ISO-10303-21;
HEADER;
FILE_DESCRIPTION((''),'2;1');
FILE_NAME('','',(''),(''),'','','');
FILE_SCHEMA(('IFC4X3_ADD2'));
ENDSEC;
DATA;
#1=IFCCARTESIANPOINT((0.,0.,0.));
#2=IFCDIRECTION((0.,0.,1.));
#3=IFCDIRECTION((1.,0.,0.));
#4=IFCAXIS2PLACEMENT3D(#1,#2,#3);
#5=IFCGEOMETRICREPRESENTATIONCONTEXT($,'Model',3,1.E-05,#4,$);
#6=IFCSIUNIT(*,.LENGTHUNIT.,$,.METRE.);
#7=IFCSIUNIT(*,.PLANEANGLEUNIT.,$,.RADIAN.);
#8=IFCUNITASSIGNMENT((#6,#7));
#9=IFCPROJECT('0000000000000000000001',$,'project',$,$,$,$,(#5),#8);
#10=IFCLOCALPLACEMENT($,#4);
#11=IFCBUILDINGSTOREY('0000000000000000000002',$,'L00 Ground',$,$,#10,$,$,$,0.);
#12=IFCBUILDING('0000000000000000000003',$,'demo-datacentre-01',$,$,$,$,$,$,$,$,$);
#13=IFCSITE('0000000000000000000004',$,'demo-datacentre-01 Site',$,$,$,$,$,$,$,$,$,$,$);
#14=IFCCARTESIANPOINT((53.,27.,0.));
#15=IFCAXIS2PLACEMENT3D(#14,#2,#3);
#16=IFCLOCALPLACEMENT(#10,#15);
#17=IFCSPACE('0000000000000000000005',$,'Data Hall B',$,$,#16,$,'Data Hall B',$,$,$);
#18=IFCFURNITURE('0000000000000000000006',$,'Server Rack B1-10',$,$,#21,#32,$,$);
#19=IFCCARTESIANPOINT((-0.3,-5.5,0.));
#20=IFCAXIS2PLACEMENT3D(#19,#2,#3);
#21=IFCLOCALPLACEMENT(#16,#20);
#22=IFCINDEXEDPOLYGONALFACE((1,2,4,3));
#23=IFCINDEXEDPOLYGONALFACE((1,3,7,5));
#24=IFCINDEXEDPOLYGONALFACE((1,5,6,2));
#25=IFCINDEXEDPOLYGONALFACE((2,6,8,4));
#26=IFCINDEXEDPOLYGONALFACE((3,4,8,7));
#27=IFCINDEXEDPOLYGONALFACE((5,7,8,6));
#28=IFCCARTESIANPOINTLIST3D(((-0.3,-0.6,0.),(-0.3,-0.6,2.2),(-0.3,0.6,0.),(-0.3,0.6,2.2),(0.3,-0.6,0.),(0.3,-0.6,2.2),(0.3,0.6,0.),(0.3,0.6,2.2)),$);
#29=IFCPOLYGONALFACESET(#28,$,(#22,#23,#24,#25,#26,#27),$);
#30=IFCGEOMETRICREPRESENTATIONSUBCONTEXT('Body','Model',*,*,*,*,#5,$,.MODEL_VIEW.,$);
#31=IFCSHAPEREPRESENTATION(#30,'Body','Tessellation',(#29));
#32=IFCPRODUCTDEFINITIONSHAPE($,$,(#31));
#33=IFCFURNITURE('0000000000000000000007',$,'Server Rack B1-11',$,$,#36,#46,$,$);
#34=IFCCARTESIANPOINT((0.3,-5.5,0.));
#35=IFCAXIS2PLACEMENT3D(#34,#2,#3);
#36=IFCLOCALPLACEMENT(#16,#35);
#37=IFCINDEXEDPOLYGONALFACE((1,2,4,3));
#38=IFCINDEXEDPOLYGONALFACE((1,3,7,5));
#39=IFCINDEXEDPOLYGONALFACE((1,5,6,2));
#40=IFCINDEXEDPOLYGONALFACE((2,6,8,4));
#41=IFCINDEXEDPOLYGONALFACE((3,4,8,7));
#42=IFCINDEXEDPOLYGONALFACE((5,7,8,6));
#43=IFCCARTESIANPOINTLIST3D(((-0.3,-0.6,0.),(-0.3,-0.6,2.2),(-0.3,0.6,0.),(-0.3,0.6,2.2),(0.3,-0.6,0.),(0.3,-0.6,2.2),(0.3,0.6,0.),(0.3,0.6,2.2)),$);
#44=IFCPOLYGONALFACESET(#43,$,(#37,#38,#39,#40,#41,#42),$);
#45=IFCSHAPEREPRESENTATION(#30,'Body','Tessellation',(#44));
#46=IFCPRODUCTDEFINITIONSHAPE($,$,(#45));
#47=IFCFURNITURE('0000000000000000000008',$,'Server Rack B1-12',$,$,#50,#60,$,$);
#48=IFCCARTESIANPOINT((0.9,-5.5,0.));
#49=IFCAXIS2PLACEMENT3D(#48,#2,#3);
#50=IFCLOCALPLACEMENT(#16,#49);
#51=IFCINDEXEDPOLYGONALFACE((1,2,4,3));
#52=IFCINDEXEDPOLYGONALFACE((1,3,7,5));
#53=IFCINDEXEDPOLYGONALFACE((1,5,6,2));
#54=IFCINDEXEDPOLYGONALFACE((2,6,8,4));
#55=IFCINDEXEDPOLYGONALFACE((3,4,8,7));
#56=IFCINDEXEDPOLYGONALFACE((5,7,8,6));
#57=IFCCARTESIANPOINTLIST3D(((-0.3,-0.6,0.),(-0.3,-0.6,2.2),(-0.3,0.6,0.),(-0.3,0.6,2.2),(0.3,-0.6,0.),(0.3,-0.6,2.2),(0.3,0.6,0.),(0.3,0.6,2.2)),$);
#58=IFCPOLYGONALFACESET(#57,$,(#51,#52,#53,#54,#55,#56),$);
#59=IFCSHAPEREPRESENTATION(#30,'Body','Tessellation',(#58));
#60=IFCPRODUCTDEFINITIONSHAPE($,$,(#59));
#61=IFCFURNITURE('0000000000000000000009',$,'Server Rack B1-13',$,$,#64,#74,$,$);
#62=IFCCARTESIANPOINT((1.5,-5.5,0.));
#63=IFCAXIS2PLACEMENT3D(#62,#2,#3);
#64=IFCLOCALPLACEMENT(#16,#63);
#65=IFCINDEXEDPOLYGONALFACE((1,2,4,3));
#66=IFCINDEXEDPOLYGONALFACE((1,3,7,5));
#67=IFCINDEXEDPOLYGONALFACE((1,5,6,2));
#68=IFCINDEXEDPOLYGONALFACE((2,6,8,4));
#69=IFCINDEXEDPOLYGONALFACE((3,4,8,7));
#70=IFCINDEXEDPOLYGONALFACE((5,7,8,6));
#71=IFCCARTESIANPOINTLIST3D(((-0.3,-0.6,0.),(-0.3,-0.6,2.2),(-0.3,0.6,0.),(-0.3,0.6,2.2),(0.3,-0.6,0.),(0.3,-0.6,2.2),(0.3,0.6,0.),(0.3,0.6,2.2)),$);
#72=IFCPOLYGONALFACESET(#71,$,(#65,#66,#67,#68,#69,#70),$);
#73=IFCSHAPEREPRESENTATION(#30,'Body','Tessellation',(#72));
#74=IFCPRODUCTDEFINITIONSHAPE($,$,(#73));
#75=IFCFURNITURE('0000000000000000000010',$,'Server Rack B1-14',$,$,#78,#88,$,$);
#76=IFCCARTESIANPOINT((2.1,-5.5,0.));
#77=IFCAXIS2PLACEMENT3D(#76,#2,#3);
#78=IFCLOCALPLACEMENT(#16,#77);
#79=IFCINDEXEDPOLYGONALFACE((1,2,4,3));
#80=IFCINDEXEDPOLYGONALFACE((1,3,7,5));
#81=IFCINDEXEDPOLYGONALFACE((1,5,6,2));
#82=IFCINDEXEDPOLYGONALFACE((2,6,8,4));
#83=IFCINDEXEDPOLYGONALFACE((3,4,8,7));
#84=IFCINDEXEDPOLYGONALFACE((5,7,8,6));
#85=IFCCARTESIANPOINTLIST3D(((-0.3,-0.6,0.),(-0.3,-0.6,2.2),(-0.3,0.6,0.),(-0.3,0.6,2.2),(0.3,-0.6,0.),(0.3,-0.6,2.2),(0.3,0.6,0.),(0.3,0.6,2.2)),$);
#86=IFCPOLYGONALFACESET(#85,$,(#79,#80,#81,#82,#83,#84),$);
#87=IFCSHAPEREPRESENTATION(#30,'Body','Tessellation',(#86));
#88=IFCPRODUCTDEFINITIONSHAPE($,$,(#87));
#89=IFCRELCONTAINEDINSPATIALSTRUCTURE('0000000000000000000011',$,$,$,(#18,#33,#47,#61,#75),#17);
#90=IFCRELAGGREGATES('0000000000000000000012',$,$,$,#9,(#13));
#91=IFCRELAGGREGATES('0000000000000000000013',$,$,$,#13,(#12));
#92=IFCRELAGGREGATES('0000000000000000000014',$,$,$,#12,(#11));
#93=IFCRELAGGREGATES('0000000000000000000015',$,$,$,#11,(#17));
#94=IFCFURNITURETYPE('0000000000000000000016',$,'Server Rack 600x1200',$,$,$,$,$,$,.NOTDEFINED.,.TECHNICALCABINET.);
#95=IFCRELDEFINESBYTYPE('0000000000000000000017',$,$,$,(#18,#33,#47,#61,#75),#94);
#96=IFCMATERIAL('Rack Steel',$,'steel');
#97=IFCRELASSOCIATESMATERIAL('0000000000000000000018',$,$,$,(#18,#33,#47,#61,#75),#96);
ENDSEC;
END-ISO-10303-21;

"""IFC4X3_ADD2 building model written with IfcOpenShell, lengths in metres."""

from ifc_helpers import new_model, si_unit, frame, origin_with_axes, place, context, subcontext, project, spatial, rectangle, extrude, material, type_object, element, save


model = new_model("IFC4X3_ADD2")

# Units and contexts
model_context = context("Model", 3, precision=1e-05, world=origin_with_axes())
body_context = subcontext(model_context, "Body", "Model", "MODEL_VIEW")
ifc_project = project(units=[si_unit("LENGTHUNIT", "METRE"), si_unit("PLANEANGLEUNIT", "RADIAN")], contexts=[model_context])

# Site, building, storey
site = spatial("IfcSite", under=ifc_project, Name="demo-datacentre-01 Site")
building = spatial("IfcBuilding", under=site, Name="demo-datacentre-01")
storey_placement = place(None, origin_with_axes())
storey = spatial("IfcBuildingStorey", under=building, at=storey_placement, Name="L00 Ground", Elevation=0.0)

# Shared definitions
space_placement = place(storey_placement, frame((53.0, 27.0, 0.0), z_axis=(0.0, 0.0, 1.0), x_axis=(1.0, 0.0, 0.0)))
space = spatial("IfcSpace", under=storey, at=space_placement, Name="Data Hall B", LongName="Data Hall B")

# Furniture
ifc_material_1 = material(Name="Rack Steel", Category="steel")
furniture_type = type_object("IfcFurnitureType", Name="Server Rack 600x1200", AssemblyPlace="NOTDEFINED", PredefinedType="TECHNICALCABINET")
for number, where, z_axis, x_axis, name in (
    (1, (-0.3, -5.5, 0.0), (0.0, 0.0, 1.0), (1.0, 0.0, 0.0), "Server Rack B1-10"),
    (2, (0.3, -5.5, 0.0), (0.0, 0.0, 1.0), (1.0, 0.0, 0.0), "Server Rack B1-11"),
    (3, (0.9, -5.5, 0.0), (0.0, 0.0, 1.0), (1.0, 0.0, 0.0), "Server Rack B1-12"),
    (4, (1.5, -5.5, 0.0), (0.0, 0.0, 1.0), (1.0, 0.0, 0.0), "Server Rack B1-13"),
    (5, (2.1, -5.5, 0.0), (0.0, 0.0, 1.0), (1.0, 0.0, 0.0), "Server Rack B1-14"),
):
    element("IfcFurniture", number, at=place(space_placement, frame(where, z_axis=z_axis, x_axis=x_axis)), inside=space, type_object=furniture_type, material=ifc_material_1, Name=name, context=body_context, shape_type="SweptSolid", body=[
        extrude(rectangle(XDim=0.6, YDim=1.2), origin_with_axes(), (0.0, 0.0, 1.0), 2.2),
    ])

save(model, "model.ifc")
